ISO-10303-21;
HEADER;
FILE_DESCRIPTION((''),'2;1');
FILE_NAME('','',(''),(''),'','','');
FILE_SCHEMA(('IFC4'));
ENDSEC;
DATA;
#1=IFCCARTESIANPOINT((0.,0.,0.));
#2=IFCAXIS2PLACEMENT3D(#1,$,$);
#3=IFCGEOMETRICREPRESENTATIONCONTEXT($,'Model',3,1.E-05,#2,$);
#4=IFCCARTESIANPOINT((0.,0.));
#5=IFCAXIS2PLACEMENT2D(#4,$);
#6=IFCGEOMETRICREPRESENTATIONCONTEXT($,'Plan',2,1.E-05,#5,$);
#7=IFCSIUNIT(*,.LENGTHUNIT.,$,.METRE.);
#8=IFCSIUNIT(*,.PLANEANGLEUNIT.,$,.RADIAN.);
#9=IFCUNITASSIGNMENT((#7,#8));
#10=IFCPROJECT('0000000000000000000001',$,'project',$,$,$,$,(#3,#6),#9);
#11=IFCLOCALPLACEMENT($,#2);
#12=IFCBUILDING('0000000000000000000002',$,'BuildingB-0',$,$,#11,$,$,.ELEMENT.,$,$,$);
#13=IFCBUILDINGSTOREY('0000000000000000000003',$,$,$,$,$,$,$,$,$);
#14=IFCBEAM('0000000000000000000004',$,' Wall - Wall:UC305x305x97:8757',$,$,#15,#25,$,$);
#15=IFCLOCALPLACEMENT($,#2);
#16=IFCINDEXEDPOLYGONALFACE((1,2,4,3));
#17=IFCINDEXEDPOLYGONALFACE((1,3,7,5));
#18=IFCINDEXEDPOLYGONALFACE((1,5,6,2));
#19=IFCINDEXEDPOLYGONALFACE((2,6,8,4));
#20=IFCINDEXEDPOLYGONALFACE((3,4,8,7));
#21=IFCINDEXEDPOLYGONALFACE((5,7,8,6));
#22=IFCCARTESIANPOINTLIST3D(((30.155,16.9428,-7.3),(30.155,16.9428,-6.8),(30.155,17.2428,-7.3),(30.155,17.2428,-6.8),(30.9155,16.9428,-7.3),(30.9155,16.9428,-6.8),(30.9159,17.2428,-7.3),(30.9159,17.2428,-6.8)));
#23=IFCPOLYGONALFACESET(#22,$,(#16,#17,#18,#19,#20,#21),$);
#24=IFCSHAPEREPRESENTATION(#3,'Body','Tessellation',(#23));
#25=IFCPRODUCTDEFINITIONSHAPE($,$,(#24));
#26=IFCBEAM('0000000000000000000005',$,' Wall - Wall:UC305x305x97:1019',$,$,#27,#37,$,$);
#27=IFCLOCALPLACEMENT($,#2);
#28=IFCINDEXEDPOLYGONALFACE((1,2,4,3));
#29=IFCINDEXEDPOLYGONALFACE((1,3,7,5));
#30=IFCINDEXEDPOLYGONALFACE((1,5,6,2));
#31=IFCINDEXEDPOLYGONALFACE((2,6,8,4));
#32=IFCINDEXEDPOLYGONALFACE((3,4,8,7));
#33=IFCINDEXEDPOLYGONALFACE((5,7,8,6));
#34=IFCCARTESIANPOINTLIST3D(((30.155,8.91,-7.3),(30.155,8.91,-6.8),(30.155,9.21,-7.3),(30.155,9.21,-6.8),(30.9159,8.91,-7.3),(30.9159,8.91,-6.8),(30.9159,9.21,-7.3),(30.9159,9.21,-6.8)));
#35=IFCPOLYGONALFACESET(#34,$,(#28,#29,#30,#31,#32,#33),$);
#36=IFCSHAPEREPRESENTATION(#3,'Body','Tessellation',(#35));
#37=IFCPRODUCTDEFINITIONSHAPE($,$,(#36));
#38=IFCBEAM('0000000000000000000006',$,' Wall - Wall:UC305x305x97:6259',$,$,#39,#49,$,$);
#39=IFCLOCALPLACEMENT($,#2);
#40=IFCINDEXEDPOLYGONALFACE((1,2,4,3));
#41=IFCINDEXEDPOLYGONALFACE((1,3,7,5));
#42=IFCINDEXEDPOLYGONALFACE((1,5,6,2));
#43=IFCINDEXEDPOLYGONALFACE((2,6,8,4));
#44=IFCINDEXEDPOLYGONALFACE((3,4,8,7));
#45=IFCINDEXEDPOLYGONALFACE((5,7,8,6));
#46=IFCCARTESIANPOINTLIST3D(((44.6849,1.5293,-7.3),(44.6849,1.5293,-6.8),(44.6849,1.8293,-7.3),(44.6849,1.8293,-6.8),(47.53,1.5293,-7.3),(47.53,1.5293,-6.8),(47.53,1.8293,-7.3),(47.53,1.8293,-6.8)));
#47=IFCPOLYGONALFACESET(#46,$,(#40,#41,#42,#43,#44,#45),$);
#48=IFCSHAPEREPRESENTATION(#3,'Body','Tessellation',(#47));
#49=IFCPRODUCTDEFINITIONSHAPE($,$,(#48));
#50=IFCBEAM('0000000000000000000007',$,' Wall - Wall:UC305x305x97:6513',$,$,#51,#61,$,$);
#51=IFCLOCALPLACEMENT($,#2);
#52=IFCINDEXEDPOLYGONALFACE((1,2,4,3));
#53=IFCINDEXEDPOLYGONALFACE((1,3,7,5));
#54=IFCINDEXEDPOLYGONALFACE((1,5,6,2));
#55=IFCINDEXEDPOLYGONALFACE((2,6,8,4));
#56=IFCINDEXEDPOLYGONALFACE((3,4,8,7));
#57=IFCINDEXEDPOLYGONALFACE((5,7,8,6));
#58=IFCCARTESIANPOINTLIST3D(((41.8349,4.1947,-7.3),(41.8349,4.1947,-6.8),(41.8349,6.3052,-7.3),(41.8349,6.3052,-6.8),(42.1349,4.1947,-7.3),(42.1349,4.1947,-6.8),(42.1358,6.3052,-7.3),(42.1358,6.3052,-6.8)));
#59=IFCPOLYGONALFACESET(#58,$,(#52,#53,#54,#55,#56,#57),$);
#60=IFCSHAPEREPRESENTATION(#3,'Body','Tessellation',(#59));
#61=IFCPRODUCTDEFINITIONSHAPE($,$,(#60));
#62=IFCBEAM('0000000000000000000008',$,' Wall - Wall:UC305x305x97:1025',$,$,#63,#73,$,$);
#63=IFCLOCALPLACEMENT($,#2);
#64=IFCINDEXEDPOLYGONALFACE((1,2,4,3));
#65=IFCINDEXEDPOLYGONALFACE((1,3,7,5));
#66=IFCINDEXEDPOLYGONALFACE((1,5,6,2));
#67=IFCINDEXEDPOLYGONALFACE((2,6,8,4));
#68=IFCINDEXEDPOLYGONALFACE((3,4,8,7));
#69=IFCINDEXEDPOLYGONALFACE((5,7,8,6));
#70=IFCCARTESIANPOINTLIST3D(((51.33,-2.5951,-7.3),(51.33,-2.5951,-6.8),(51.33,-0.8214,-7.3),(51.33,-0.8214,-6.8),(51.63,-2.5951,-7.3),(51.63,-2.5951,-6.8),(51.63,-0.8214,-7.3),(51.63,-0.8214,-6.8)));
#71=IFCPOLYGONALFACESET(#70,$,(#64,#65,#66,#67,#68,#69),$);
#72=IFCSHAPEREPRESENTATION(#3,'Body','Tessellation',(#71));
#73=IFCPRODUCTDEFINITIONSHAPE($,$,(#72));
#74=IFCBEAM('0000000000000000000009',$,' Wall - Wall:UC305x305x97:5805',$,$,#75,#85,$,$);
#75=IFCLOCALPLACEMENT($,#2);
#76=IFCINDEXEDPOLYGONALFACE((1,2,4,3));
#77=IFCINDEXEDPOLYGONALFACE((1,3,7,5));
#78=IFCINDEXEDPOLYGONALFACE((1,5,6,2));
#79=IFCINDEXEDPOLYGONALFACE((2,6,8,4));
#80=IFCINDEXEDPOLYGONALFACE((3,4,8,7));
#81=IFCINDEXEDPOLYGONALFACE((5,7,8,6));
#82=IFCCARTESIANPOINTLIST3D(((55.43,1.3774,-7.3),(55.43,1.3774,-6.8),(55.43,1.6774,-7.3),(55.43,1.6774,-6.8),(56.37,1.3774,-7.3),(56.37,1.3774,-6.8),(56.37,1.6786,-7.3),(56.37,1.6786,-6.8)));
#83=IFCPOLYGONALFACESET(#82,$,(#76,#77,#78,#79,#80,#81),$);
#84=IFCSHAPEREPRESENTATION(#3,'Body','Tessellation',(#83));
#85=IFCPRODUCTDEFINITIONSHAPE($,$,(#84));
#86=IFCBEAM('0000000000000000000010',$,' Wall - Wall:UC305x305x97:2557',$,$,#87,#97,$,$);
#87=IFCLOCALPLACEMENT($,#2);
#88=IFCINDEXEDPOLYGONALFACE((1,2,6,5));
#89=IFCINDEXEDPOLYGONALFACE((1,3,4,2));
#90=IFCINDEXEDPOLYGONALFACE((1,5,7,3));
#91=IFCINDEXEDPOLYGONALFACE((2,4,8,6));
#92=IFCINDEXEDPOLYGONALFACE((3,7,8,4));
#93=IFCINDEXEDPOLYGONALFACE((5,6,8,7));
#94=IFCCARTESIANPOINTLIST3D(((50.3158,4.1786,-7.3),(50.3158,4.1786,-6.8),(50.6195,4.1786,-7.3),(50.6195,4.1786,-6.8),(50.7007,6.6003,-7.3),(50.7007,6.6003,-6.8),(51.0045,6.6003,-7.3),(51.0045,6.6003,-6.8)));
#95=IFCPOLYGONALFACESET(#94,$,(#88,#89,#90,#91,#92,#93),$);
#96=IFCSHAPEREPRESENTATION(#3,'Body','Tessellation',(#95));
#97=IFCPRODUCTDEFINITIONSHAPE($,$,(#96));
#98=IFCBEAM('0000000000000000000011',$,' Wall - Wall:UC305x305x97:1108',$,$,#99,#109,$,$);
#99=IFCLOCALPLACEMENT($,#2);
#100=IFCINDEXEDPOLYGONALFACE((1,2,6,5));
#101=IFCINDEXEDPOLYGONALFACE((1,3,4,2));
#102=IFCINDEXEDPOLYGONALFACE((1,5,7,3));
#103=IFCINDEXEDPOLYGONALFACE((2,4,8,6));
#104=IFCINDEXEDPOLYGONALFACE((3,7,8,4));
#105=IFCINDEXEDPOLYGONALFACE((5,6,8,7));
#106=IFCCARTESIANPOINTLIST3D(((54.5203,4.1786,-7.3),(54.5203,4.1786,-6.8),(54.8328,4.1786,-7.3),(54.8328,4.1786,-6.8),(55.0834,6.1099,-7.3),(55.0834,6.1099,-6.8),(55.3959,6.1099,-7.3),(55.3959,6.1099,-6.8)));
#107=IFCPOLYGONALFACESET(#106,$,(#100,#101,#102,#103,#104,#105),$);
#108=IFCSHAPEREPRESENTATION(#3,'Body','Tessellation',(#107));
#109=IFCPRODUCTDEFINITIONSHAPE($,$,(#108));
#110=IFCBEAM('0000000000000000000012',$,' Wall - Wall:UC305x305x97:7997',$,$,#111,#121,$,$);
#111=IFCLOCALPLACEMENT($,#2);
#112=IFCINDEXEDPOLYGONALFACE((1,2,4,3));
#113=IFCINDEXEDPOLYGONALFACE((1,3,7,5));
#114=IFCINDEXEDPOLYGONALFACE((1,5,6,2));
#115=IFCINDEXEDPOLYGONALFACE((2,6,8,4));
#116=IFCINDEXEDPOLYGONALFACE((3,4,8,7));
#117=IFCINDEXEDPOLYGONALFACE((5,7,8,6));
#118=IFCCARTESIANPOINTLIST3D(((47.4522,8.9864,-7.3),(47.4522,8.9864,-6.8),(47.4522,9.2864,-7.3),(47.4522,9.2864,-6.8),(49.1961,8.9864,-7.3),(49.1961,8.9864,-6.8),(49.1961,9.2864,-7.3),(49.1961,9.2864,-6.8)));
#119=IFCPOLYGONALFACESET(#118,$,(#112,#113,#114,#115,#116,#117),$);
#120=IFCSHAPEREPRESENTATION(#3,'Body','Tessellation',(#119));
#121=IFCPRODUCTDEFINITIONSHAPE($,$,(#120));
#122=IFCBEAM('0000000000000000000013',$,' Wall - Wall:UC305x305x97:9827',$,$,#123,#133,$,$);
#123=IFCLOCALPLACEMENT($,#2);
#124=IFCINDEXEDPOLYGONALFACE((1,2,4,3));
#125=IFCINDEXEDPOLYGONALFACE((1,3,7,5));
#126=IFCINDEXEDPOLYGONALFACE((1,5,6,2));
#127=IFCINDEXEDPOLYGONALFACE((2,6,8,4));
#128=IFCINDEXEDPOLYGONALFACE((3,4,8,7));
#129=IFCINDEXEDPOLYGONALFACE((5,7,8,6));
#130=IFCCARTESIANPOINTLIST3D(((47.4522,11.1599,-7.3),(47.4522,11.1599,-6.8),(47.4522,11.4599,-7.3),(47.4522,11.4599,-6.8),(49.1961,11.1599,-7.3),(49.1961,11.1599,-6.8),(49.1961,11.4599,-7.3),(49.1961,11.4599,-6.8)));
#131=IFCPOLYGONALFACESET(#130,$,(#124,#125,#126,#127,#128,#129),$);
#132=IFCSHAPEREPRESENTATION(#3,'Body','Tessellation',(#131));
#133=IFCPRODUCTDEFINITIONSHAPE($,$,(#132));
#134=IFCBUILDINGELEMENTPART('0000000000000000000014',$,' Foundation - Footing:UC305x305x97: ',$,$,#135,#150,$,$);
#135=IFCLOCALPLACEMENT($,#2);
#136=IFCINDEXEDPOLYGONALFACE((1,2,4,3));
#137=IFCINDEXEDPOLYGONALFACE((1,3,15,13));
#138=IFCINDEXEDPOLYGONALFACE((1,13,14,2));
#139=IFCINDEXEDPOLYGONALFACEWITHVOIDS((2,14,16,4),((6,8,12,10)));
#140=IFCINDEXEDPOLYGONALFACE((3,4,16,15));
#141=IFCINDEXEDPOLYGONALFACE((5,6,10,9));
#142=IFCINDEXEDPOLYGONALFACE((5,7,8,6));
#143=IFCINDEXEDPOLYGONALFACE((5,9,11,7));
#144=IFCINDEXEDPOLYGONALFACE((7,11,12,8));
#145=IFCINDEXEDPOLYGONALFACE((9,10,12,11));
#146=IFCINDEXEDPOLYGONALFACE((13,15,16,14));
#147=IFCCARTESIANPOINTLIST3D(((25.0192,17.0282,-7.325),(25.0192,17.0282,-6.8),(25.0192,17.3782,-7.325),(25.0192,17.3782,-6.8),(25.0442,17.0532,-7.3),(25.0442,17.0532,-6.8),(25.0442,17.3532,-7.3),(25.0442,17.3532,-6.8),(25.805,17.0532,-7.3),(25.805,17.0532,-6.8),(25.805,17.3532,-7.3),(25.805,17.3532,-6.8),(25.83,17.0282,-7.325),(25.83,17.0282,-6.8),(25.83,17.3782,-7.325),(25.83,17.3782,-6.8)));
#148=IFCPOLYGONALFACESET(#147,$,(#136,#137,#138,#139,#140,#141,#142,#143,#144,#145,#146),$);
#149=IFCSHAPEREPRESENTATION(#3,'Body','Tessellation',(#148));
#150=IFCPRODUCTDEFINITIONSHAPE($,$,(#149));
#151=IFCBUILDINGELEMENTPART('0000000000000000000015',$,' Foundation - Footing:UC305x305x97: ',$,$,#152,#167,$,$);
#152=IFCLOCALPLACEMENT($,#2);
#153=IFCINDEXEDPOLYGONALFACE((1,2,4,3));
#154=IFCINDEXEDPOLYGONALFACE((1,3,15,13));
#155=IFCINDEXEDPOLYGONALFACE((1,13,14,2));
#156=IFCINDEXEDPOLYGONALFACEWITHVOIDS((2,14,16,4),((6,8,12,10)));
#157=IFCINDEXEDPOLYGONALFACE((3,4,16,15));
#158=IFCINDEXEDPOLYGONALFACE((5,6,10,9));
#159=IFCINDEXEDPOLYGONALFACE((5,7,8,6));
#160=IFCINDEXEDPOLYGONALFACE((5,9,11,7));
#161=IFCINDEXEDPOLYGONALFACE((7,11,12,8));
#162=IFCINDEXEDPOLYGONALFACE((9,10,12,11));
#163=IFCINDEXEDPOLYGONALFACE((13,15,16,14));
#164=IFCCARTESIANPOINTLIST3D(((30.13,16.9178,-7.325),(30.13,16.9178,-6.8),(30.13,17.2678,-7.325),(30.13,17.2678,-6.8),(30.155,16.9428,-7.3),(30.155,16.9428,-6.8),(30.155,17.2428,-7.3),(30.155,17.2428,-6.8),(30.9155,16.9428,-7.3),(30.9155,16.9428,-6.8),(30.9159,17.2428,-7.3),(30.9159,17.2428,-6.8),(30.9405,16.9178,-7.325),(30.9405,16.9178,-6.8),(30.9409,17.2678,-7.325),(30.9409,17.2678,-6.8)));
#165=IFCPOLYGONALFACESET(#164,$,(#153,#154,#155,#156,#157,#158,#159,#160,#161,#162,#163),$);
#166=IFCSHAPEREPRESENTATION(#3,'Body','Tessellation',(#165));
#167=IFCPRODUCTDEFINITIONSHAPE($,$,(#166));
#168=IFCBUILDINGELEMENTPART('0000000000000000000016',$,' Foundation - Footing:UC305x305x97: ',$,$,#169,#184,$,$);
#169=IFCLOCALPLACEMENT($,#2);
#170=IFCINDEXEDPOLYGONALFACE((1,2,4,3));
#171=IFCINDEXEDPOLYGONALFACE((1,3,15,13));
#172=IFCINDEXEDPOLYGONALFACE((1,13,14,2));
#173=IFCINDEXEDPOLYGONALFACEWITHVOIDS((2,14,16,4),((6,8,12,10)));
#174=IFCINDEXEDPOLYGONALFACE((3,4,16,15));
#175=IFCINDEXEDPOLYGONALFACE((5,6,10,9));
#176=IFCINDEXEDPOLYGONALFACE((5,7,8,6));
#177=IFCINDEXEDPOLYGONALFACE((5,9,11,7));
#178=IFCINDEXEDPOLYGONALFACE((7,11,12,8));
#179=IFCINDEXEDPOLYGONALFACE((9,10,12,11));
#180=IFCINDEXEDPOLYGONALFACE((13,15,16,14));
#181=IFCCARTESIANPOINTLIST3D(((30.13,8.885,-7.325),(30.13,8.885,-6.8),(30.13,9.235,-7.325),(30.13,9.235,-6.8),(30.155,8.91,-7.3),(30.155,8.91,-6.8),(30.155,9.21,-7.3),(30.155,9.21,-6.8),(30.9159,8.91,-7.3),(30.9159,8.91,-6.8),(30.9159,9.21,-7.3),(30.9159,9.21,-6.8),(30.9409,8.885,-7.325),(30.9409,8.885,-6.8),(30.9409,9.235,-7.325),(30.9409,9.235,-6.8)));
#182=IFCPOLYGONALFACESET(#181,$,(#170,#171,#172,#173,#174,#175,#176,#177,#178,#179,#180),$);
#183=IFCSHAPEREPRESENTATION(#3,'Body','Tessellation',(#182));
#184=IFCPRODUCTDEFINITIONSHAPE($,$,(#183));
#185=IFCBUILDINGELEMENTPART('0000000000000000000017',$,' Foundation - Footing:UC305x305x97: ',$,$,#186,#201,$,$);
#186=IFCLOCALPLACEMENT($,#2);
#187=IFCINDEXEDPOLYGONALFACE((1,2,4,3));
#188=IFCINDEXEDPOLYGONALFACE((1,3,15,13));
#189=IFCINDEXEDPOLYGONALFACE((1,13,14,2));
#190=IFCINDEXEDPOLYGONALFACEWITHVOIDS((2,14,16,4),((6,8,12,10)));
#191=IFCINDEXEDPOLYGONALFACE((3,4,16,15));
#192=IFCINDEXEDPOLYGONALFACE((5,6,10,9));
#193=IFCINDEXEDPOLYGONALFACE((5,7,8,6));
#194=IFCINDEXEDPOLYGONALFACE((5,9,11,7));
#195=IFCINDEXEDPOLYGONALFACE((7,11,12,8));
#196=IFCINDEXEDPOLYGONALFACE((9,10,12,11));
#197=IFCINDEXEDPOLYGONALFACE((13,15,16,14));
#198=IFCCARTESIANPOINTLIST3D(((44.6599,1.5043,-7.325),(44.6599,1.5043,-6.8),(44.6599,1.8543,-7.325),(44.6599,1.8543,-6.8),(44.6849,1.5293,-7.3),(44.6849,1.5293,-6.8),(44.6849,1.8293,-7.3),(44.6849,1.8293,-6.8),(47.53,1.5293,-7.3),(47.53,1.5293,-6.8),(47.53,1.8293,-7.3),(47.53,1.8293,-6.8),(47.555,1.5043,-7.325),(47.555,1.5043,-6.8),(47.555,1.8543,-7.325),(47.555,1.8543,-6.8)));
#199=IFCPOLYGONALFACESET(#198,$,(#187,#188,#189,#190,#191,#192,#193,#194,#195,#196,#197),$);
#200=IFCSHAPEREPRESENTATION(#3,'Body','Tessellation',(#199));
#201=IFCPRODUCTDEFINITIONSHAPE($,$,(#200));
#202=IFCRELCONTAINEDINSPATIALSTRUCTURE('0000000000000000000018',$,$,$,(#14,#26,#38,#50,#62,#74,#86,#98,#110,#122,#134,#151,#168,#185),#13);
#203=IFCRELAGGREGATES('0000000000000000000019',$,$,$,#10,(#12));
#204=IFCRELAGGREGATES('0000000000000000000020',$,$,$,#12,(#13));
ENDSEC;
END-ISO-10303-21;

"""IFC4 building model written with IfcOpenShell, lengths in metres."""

from ifc_helpers import new_model, si_unit, origin, origin_2d, place, context, project, spatial, polyline, outline, extrude, element, save


model = new_model("IFC4")

# Units and contexts
model_context = context("Model", 3, precision=1e-05, world=origin())
plan_context = context("Plan", 2, precision=1e-05, world=origin_2d())
ifc_project = project(units=[si_unit("LENGTHUNIT", "METRE"), si_unit("PLANEANGLEUNIT", "RADIAN")], contexts=[model_context, plan_context])

# Building, storey
building_placement = place(None, origin())
building = spatial("IfcBuilding", under=ifc_project, at=building_placement, Name="BuildingB-0", CompositionType="ELEMENT")
storey = spatial("IfcBuildingStorey", under=building)

# Beams
element("IfcBeam", 1, inside=storey, Name=" Wall - Wall:UC305x305x97:8757", context=model_context, shape_type="SweptSolid", body=[
    extrude(outline(polyline([(30.155, 16.9428, -7.3), (30.9155, 16.9428, -7.3), (30.9159, 17.2428, -7.3), (30.155, 17.2428, -7.3), (30.155, 16.9428, -7.3)])), None, (0.0, 0.0, 1.0), 0.5),
])
element("IfcBeam", 2, inside=storey, Name=" Wall - Wall:UC305x305x97:1019", context=model_context, shape_type="SweptSolid", body=[
    extrude(outline(polyline([(30.155, 8.91, -7.3), (30.9159, 8.91, -7.3), (30.9159, 9.21, -7.3), (30.155, 9.21, -7.3), (30.155, 8.91, -7.3)])), None, (0.0, 0.0, 1.0), 0.5),
])
element("IfcBeam", 3, inside=storey, Name=" Wall - Wall:UC305x305x97:6259", context=model_context, shape_type="SweptSolid", body=[
    extrude(outline(polyline([(44.6849, 1.5293, -7.3), (44.6849, 1.8293, -7.3), (47.53, 1.8293, -7.3), (47.53, 1.5293, -7.3), (44.6849, 1.5293, -7.3)])), None, (0.0, 0.0, 1.0), 0.5),
])
element("IfcBeam", 4, inside=storey, Name=" Wall - Wall:UC305x305x97:6513", context=model_context, shape_type="SweptSolid", body=[
    extrude(outline(polyline([(41.8349, 4.1947, -7.3), (42.1349, 4.1947, -7.3), (42.1358, 6.3052, -7.3), (41.8349, 6.3052, -7.3), (41.8349, 4.1947, -7.3)])), None, (0.0, 0.0, 1.0), 0.5),
])
element("IfcBeam", 5, inside=storey, Name=" Wall - Wall:UC305x305x97:1025", context=model_context, shape_type="SweptSolid", body=[
    extrude(outline(polyline([(51.33, -2.5951, -7.3), (51.63, -2.5951, -7.3), (51.63, -0.8214, -7.3), (51.33, -0.8214, -7.3), (51.33, -2.5951, -7.3)])), None, (0.0, 0.0, 1.0), 0.5),
])
element("IfcBeam", 6, inside=storey, Name=" Wall - Wall:UC305x305x97:5805", context=model_context, shape_type="SweptSolid", body=[
    extrude(outline(polyline([(55.43, 1.3774, -7.3), (55.43, 1.6774, -7.3), (56.37, 1.6786, -7.3), (56.37, 1.3774, -7.3), (55.43, 1.3774, -7.3)])), None, (0.0, 0.0, 1.0), 0.5),
])
element("IfcBeam", 7, inside=storey, Name=" Wall - Wall:UC305x305x97:2557", context=model_context, shape_type="SweptSolid", body=[
    extrude(outline(polyline([(50.3158, 4.1786, -7.3), (50.7007, 6.6003, -7.3), (51.0045, 6.6003, -7.3), (50.6195, 4.1786, -7.3), (50.3158, 4.1786, -7.3)])), None, (0.0, 0.0, 1.0), 0.5),
])
element("IfcBeam", 8, inside=storey, Name=" Wall - Wall:UC305x305x97:1108", context=model_context, shape_type="SweptSolid", body=[
    extrude(outline(polyline([(54.8328, 4.1786, -7.3), (54.5203, 4.1786, -7.3), (55.0834, 6.1099, -7.3), (55.3959, 6.1099, -7.3), (54.8328, 4.1786, -7.3)])), None, (0.0, 0.0, 1.0), 0.5),
])
element("IfcBeam", 9, inside=storey, Name=" Wall - Wall:UC305x305x97:7997", context=model_context, shape_type="SweptSolid", body=[
    extrude(outline(polyline([(47.4522, 8.9864, -7.3), (49.1961, 8.9864, -7.3), (49.1961, 9.2864, -7.3), (47.4522, 9.2864, -7.3), (47.4522, 8.9864, -7.3)])), None, (0.0, 0.0, 1.0), 0.5),
])
element("IfcBeam", 10, inside=storey, Name=" Wall - Wall:UC305x305x97:9827", context=model_context, shape_type="SweptSolid", body=[
    extrude(outline(polyline([(47.4522, 11.1599, -7.3), (47.4522, 11.4599, -7.3), (49.1961, 11.4599, -7.3), (49.1961, 11.1599, -7.3), (47.4522, 11.1599, -7.3)])), None, (0.0, 0.0, 1.0), 0.5),
])

# Building element parts, openings
building_element_part_1 = element("IfcBuildingElementPart", 11, inside=storey, Name=" Foundation - Footing:UC305x305x97: ", context=model_context, shape_type="SweptSolid", body=[
    extrude(outline(polyline([(25.0192, 17.0282, -7.325), (25.0192, 17.3782, -7.325), (25.83, 17.3782, -7.325), (25.83, 17.0282, -7.325), (25.0192, 17.0282, -7.325)])), None, (0.0, 0.0, 1.0), 0.525),
])
element("IfcOpeningElement", 12, inside=storey, cuts=building_element_part_1, context=model_context, shape_type="SweptSolid", body=[
    extrude(outline(polyline([(25.0442, 17.0532, -7.3), (25.0442, 17.3532, -7.3), (25.805, 17.3532, -7.3), (25.805, 17.0532, -7.3), (25.0442, 17.0532, -7.3)])), None, (0.0, 0.0, 1.0), 0.5),
])
building_element_part_2 = element("IfcBuildingElementPart", 13, inside=storey, Name=" Foundation - Footing:UC305x305x97: ", context=model_context, shape_type="SweptSolid", body=[
    extrude(outline(polyline([(30.13, 16.9178, -7.325), (30.9405, 16.9178, -7.325), (30.9409, 17.2678, -7.325), (30.13, 17.2678, -7.325), (30.13, 16.9178, -7.325)])), None, (0.0, 0.0, 1.0), 0.525),
])
element("IfcOpeningElement", 14, inside=storey, cuts=building_element_part_2, context=model_context, shape_type="SweptSolid", body=[
    extrude(outline(polyline([(30.155, 16.9428, -7.3), (30.9155, 16.9428, -7.3), (30.9159, 17.2428, -7.3), (30.155, 17.2428, -7.3), (30.155, 16.9428, -7.3)])), None, (0.0, 0.0, 1.0), 0.5),
])
building_element_part_3 = element("IfcBuildingElementPart", 15, inside=storey, Name=" Foundation - Footing:UC305x305x97: ", context=model_context, shape_type="SweptSolid", body=[
    extrude(outline(polyline([(30.13, 8.885, -7.325), (30.9409, 8.885, -7.325), (30.9409, 9.235, -7.325), (30.13, 9.235, -7.325), (30.13, 8.885, -7.325)])), None, (0.0, 0.0, 1.0), 0.525),
])
element("IfcOpeningElement", 16, inside=storey, cuts=building_element_part_3, context=model_context, shape_type="SweptSolid", body=[
    extrude(outline(polyline([(30.155, 8.91, -7.3), (30.9159, 8.91, -7.3), (30.9159, 9.21, -7.3), (30.155, 9.21, -7.3), (30.155, 8.91, -7.3)])), None, (0.0, 0.0, 1.0), 0.5),
])
building_element_part_4 = element("IfcBuildingElementPart", 17, inside=storey, Name=" Foundation - Footing:UC305x305x97: ", context=model_context, shape_type="SweptSolid", body=[
    extrude(outline(polyline([(44.6599, 1.5043, -7.325), (44.6599, 1.8543, -7.325), (47.555, 1.8543, -7.325), (47.555, 1.5043, -7.325), (44.6599, 1.5043, -7.325)])), None, (0.0, 0.0, 1.0), 0.525),
])
element("IfcOpeningElement", 18, inside=storey, cuts=building_element_part_4, context=model_context, shape_type="SweptSolid", body=[
    extrude(outline(polyline([(44.6849, 1.5293, -7.3), (44.6849, 1.8293, -7.3), (47.53, 1.8293, -7.3), (47.53, 1.5293, -7.3), (44.6849, 1.5293, -7.3)])), None, (0.0, 0.0, 1.0), 0.5),
])

save(model, "model.ifc")
